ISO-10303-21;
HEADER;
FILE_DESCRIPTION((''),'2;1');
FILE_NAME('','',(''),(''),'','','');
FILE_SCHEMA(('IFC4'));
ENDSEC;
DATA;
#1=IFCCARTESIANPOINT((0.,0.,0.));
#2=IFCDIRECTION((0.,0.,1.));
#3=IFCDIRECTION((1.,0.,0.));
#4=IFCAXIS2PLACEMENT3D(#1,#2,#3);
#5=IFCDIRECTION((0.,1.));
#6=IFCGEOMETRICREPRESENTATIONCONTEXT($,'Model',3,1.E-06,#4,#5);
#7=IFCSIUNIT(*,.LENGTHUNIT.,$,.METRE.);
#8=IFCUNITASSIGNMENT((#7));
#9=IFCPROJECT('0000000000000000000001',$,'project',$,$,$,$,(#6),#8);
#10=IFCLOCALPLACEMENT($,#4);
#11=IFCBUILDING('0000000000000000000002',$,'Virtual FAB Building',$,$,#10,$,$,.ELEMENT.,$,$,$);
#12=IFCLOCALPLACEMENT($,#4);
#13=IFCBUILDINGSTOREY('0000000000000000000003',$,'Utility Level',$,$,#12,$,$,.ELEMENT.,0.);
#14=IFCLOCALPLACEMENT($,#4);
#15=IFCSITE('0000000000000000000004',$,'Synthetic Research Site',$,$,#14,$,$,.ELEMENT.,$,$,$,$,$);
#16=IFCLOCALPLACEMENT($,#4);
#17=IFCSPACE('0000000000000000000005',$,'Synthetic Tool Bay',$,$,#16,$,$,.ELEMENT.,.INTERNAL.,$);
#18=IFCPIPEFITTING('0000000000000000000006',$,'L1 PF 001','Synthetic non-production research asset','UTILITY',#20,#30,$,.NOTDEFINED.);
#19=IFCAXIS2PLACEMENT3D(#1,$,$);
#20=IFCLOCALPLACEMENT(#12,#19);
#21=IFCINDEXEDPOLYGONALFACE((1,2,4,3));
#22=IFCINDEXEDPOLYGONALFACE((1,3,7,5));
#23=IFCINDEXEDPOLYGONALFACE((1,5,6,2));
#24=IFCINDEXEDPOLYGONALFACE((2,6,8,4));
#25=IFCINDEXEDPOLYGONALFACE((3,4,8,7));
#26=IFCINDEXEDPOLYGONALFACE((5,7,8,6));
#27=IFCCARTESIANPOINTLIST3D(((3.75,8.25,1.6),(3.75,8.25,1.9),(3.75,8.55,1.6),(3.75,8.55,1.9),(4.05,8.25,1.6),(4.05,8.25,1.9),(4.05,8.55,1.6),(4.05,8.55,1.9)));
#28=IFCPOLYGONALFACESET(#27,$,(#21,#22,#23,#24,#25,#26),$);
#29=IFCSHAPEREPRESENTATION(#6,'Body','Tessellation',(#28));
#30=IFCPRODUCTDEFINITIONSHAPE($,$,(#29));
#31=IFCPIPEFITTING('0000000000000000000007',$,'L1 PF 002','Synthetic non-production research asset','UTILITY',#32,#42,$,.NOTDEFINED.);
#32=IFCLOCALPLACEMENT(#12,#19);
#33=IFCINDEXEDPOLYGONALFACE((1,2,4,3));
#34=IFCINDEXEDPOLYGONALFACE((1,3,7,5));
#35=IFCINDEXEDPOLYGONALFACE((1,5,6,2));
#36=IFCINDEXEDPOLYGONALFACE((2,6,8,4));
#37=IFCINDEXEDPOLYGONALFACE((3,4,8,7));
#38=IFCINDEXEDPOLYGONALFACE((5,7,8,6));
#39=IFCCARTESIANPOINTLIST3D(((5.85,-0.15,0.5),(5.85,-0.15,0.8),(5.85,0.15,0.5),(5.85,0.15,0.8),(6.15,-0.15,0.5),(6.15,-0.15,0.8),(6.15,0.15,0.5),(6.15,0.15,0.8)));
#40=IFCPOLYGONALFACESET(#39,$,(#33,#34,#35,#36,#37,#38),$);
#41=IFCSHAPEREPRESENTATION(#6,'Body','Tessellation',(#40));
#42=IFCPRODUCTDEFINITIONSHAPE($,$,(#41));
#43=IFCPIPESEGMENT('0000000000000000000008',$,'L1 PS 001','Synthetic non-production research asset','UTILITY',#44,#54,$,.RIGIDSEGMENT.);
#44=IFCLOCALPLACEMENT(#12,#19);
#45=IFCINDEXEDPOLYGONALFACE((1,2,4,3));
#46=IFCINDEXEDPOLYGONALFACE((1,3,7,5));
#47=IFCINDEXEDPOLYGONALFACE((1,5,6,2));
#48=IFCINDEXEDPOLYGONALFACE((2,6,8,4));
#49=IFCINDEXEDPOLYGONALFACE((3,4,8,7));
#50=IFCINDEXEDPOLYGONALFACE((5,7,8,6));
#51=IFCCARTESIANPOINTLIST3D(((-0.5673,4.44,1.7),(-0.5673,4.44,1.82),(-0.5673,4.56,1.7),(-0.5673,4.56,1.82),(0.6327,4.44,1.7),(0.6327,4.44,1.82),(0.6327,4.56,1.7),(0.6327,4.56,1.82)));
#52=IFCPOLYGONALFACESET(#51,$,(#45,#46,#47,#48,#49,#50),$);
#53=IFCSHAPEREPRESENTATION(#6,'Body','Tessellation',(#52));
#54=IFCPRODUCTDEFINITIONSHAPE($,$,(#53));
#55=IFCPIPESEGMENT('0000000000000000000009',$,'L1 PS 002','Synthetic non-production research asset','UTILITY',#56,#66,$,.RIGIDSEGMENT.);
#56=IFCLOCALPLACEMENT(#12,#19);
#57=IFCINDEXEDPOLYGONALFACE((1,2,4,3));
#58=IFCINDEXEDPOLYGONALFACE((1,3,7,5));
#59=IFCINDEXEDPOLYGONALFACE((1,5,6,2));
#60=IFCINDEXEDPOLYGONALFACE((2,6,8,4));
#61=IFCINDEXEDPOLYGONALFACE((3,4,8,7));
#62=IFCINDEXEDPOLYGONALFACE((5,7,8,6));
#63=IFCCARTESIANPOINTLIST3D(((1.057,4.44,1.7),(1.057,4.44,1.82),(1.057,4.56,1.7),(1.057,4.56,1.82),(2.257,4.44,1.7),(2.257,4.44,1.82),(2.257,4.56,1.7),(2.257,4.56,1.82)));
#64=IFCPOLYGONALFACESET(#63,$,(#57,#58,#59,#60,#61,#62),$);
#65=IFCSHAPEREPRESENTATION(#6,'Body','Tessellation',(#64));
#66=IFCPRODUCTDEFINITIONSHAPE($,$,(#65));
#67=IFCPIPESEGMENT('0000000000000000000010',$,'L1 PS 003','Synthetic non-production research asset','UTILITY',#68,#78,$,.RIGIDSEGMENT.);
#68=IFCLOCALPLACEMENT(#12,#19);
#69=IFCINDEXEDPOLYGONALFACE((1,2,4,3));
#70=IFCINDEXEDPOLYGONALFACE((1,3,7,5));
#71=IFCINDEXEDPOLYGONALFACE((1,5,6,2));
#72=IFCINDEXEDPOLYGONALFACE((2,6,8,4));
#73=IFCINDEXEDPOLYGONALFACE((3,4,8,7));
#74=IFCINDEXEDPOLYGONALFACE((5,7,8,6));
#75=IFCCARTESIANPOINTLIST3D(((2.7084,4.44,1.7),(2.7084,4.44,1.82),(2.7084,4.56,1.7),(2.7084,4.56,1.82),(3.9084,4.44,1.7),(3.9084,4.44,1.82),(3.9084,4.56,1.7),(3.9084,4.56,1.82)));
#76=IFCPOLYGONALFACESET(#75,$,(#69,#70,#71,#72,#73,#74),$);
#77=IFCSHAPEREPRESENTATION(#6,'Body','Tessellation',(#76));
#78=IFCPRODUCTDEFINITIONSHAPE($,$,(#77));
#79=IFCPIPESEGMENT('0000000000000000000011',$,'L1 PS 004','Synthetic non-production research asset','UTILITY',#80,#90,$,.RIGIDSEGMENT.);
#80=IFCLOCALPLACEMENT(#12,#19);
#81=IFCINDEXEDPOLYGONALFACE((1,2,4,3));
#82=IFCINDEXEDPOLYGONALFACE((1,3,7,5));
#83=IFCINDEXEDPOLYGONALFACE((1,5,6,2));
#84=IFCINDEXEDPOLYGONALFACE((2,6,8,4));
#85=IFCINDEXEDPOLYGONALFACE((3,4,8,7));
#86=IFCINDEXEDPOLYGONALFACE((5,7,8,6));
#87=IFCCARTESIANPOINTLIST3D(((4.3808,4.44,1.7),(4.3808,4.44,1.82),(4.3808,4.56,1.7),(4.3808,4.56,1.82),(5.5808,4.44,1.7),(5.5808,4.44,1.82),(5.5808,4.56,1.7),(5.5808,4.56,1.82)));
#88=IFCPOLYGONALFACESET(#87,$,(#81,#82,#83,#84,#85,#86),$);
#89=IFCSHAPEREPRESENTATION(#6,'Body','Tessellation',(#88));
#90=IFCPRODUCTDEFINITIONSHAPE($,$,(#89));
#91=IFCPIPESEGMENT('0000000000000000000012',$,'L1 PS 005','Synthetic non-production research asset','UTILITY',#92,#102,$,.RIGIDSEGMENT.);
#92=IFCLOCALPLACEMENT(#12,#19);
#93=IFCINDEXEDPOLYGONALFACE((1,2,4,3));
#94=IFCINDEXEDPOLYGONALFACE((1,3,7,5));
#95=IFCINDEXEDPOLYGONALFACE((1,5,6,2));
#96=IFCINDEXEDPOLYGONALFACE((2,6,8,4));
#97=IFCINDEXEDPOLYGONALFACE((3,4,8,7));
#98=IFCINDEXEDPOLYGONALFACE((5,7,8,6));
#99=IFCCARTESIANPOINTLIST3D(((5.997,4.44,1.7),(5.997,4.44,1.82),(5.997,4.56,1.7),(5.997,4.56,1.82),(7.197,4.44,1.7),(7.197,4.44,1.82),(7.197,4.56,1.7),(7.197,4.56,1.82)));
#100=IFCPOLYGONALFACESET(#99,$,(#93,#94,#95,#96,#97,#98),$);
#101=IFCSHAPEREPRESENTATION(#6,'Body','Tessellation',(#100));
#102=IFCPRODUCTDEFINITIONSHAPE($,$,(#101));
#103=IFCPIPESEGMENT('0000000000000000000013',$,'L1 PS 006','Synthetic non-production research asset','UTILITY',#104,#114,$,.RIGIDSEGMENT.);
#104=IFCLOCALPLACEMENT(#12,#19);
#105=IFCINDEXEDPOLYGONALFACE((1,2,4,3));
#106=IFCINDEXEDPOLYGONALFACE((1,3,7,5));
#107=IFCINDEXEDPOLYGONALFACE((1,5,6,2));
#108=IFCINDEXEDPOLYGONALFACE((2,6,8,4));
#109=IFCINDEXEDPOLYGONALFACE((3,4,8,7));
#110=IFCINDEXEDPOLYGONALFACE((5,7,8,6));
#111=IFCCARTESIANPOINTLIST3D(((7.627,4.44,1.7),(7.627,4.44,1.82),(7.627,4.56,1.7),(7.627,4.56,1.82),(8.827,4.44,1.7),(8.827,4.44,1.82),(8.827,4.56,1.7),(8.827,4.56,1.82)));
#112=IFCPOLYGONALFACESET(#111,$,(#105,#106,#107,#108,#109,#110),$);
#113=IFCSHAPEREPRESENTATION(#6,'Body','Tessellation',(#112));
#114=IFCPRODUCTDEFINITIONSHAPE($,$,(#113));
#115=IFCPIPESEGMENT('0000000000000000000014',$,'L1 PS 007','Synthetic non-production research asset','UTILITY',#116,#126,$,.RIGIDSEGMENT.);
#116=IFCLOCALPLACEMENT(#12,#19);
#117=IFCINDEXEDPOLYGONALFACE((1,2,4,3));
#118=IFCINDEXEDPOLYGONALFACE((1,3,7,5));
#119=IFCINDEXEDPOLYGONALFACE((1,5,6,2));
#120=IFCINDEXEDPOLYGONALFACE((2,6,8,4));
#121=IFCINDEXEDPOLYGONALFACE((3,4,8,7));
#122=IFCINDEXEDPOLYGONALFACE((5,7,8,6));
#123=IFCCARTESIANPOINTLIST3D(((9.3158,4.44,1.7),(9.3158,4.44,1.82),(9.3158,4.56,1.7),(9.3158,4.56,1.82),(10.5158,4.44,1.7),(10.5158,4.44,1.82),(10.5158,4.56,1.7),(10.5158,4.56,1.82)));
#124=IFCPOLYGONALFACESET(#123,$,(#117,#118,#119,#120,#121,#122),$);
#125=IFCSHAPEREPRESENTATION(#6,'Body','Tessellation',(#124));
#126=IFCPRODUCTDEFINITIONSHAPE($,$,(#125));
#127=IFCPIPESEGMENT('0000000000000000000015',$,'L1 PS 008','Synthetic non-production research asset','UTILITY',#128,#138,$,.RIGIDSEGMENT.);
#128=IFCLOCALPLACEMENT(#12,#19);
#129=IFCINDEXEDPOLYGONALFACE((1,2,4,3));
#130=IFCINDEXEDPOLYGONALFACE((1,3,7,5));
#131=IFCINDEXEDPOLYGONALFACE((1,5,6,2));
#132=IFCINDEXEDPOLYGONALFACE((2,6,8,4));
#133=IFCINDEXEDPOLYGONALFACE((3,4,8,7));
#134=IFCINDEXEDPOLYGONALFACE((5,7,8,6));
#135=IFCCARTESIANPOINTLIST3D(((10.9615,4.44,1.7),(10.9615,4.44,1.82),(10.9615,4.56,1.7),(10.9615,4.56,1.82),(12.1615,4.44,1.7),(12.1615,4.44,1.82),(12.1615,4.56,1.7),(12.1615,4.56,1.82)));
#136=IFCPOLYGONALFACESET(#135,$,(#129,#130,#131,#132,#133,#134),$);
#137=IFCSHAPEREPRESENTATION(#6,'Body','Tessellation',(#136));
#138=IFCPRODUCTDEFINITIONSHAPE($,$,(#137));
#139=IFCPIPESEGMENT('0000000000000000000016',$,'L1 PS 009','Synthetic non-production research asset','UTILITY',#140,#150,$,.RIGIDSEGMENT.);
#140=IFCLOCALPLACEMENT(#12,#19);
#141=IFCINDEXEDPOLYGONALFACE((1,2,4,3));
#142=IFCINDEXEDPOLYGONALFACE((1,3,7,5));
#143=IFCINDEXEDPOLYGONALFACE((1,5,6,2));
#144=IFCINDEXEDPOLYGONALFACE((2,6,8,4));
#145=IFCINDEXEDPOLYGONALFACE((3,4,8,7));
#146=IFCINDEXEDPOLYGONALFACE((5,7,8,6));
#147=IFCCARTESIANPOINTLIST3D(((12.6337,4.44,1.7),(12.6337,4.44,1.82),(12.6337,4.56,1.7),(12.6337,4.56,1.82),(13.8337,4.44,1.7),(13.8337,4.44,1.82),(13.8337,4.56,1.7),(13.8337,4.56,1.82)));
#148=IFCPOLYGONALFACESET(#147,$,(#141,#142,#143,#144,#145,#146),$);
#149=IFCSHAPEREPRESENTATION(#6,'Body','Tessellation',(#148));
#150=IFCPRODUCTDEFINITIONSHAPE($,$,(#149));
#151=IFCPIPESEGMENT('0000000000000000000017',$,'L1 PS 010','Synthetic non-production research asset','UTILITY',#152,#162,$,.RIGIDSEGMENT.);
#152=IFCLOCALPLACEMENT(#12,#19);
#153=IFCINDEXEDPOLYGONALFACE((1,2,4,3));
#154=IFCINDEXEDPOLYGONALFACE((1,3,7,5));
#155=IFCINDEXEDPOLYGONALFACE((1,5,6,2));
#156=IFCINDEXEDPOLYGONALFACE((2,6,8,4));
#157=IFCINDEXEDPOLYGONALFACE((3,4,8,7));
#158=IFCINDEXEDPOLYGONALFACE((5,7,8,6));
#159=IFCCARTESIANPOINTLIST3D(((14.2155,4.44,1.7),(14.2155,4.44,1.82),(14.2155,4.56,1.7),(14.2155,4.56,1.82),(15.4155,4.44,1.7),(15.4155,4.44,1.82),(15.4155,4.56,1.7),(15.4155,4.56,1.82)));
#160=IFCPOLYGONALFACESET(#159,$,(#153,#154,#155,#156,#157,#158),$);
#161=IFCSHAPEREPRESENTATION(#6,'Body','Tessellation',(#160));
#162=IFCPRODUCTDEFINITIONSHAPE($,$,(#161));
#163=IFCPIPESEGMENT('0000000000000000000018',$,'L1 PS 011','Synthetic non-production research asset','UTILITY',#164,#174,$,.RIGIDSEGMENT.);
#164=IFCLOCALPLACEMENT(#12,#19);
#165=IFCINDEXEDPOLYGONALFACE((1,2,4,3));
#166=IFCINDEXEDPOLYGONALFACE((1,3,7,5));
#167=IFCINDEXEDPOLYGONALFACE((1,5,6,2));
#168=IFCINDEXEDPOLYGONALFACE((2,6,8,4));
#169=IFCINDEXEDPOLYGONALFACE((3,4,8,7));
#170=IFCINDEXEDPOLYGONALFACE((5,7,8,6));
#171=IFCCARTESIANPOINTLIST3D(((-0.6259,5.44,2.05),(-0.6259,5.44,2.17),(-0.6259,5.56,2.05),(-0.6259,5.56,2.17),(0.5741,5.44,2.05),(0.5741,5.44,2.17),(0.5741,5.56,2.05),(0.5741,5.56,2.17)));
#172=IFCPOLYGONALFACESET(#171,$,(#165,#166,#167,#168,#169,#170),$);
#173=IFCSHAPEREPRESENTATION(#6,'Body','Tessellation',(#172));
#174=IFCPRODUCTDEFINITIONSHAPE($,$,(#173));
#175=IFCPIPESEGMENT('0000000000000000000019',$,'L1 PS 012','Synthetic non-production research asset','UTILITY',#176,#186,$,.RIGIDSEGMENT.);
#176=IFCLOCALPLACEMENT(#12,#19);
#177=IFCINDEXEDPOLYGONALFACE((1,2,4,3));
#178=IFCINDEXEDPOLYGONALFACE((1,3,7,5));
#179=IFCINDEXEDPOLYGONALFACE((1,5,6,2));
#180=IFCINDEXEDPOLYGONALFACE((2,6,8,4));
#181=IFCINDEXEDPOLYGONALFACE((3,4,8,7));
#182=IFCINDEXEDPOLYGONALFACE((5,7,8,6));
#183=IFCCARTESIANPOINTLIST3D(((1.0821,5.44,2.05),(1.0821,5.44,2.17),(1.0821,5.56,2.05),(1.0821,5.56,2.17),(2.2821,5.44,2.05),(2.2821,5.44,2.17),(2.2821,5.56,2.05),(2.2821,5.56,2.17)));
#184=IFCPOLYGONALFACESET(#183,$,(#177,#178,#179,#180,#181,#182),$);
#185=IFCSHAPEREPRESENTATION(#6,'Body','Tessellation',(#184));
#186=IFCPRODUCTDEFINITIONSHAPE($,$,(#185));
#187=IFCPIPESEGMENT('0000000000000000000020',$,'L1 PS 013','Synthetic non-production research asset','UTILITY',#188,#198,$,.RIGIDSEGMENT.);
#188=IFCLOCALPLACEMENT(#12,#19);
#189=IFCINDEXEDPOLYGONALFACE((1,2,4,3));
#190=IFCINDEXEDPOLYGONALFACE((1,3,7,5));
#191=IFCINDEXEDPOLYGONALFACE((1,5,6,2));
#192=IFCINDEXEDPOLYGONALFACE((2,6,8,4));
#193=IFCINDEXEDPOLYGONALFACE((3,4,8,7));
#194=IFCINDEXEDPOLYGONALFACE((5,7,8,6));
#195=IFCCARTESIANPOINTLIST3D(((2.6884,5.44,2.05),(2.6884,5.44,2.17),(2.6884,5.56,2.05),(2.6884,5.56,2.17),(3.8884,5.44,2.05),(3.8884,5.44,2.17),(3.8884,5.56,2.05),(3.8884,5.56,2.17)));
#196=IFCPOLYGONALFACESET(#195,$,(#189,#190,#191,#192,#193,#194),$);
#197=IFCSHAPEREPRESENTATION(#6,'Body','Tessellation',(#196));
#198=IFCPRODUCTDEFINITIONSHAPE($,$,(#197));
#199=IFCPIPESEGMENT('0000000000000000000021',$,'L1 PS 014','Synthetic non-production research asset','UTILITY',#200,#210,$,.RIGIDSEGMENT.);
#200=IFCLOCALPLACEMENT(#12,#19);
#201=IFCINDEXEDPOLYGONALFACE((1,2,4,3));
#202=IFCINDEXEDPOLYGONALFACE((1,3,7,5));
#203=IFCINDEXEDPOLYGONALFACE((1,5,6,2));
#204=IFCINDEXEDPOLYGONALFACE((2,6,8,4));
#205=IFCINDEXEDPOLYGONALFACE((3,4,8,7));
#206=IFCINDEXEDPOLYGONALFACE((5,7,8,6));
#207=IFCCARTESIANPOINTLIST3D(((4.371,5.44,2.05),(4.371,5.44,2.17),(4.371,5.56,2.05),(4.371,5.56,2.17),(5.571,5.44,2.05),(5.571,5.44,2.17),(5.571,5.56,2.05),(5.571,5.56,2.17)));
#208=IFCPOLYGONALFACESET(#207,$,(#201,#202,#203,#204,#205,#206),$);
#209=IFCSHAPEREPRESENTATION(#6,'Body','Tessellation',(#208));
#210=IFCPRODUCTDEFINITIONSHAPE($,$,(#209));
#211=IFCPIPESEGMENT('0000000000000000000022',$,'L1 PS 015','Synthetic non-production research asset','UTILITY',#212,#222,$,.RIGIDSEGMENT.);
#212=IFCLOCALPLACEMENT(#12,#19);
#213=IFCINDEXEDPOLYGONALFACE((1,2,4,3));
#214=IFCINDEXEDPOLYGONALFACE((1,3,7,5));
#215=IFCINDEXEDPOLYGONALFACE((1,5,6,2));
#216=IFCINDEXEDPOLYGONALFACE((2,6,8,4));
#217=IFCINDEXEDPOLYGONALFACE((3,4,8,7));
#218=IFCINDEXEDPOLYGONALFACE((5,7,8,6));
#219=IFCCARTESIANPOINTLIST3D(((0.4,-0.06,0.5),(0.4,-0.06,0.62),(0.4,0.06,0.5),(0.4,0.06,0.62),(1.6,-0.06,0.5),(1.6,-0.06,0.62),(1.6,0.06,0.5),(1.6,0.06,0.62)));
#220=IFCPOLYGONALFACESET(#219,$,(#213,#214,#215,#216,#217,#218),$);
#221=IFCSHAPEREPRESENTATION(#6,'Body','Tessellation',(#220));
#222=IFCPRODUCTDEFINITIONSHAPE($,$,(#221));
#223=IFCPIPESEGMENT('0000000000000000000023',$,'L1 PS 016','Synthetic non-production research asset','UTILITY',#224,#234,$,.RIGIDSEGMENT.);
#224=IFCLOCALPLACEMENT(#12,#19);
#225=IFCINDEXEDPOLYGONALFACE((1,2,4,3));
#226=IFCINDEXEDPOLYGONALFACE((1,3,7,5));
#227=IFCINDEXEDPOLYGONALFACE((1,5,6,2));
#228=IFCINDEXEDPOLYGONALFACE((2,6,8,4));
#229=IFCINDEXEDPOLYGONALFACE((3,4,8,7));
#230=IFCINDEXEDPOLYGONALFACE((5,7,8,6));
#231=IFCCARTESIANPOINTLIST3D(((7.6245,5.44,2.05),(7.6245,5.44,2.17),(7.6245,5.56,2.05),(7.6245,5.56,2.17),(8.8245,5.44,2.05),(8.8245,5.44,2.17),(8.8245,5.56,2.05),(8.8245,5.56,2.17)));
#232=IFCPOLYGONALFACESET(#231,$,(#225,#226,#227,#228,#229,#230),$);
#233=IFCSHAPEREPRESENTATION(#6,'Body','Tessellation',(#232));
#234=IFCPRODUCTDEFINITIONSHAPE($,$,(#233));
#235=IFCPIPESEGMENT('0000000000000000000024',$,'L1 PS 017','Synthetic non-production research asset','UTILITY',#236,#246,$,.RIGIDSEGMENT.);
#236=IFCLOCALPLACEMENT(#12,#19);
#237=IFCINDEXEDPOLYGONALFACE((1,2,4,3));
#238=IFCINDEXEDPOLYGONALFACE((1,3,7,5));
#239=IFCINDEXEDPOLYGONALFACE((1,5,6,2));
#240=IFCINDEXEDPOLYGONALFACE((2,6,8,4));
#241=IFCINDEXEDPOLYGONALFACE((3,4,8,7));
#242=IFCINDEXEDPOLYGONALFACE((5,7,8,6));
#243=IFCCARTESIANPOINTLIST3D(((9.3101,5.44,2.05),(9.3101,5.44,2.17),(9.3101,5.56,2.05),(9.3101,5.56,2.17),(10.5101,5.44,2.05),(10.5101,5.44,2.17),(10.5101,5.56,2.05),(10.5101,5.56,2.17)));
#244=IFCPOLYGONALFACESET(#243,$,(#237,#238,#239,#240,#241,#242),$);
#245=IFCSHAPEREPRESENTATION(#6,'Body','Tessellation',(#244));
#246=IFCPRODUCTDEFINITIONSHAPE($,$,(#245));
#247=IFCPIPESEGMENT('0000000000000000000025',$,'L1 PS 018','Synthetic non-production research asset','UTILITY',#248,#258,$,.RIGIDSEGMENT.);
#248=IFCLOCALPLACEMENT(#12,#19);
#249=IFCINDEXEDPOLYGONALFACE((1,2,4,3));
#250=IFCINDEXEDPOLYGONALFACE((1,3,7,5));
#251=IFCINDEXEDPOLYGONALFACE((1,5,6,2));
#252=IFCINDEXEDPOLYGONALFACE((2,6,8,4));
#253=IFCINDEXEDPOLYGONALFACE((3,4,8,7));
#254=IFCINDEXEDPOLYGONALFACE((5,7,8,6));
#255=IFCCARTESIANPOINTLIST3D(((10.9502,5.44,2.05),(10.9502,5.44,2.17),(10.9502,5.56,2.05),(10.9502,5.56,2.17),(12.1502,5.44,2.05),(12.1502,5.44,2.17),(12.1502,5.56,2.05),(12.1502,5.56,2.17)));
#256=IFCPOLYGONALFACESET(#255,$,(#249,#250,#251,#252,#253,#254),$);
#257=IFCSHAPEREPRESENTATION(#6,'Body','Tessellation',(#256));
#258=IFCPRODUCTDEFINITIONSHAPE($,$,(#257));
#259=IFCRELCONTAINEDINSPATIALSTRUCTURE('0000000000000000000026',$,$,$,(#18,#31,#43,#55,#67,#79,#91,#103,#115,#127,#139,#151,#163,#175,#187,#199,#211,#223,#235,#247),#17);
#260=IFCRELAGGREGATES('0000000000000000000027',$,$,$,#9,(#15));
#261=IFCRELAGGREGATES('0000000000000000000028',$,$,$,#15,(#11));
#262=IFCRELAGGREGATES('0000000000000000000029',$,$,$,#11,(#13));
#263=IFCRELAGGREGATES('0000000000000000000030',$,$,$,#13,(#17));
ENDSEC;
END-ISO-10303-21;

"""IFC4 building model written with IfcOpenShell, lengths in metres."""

from ifc_helpers import new_model, si_unit, direction, frame, origin_with_axes, origin_2d_with_axis, place, context, project, spatial, rectangle, extrude, element, save


model = new_model("IFC4")

# Units and contexts
model_context = context("Model", 3, precision=1e-06, world=origin_with_axes(), true_north=direction((0.0, 1.0)))
ifc_project = project(units=[si_unit("LENGTHUNIT", "METRE")], contexts=[model_context])

# Site, building, storey, space
site_placement = place(None, origin_with_axes())
site = spatial("IfcSite", under=ifc_project, at=site_placement, Name="Synthetic Research Site", CompositionType="ELEMENT")
building_placement = place(None, origin_with_axes())
building = spatial("IfcBuilding", under=site, at=building_placement, Name="Virtual FAB Building", CompositionType="ELEMENT")
storey_placement = place(None, origin_with_axes())
storey = spatial("IfcBuildingStorey", under=building, at=storey_placement, Name="Utility Level", CompositionType="ELEMENT", Elevation=0.0)
space_placement = place(None, origin_with_axes())
space = spatial("IfcSpace", under=storey, at=space_placement, Name="Synthetic Tool Bay", CompositionType="ELEMENT", PredefinedType="INTERNAL")

# Pipe fittings
for number, where, z_axis, x_axis, name in (
    (1, (3.9, 8.4, 1.6), (0.0, 0.0, 1.0), (1.0, 0.0, 0.0), "L1 PF 001"),
    (2, (6.0, 0.0, 0.5), (0.0, 0.0, 1.0), (1.0, 0.0, 0.0), "L1 PF 002"),
):
    element("IfcPipeFitting", number, at=place(None, frame(where, z_axis=z_axis, x_axis=x_axis)), inside=space, Name=name, Description="Synthetic non-production research asset", ObjectType="UTILITY", PredefinedType="NOTDEFINED", context=model_context, shape_type="SweptSolid", body=[
        extrude(rectangle(XDim=0.3, YDim=0.3, at=origin_2d_with_axis()), origin_with_axes(), (0.0, 0.0, 1.0), 0.3),
    ])

# Pipe segments
for number, where, z_axis, x_axis, name in (
    (3, (0.0327, 4.5, 1.7), (0.0, 0.0, 1.0), (1.0, 0.0, 0.0), "L1 PS 001"),
    (4, (1.657, 4.5, 1.7), (0.0, 0.0, 1.0), (1.0, 0.0, 0.0), "L1 PS 002"),
    (5, (3.3084, 4.5, 1.7), (0.0, 0.0, 1.0), (1.0, 0.0, 0.0), "L1 PS 003"),
    (6, (4.9808, 4.5, 1.7), (0.0, 0.0, 1.0), (1.0, 0.0, 0.0), "L1 PS 004"),
    (7, (6.597, 4.5, 1.7), (0.0, 0.0, 1.0), (1.0, 0.0, 0.0), "L1 PS 005"),
    (8, (8.227, 4.5, 1.7), (0.0, 0.0, 1.0), (1.0, 0.0, 0.0), "L1 PS 006"),
    (9, (9.9158, 4.5, 1.7), (0.0, 0.0, 1.0), (1.0, 0.0, 0.0), "L1 PS 007"),
    (10, (11.5615, 4.5, 1.7), (0.0, 0.0, 1.0), (1.0, 0.0, 0.0), "L1 PS 008"),
    (11, (13.2337, 4.5, 1.7), (0.0, 0.0, 1.0), (1.0, 0.0, 0.0), "L1 PS 009"),
    (12, (14.8155, 4.5, 1.7), (0.0, 0.0, 1.0), (1.0, 0.0, 0.0), "L1 PS 010"),
    (13, (-0.0259, 5.5, 2.05), (0.0, 0.0, 1.0), (1.0, 0.0, 0.0), "L1 PS 011"),
    (14, (1.6821, 5.5, 2.05), (0.0, 0.0, 1.0), (1.0, 0.0, 0.0), "L1 PS 012"),
    (15, (3.2884, 5.5, 2.05), (0.0, 0.0, 1.0), (1.0, 0.0, 0.0), "L1 PS 013"),
    (16, (4.971, 5.5, 2.05), (0.0, 0.0, 1.0), (1.0, 0.0, 0.0), "L1 PS 014"),
    (17, (1.0, 0.0, 0.5), (0.0, 0.0, 1.0), (1.0, 0.0, 0.0), "L1 PS 015"),
    (18, (8.2245, 5.5, 2.05), (0.0, 0.0, 1.0), (1.0, 0.0, 0.0), "L1 PS 016"),
    (19, (9.9101, 5.5, 2.05), (0.0, 0.0, 1.0), (1.0, 0.0, 0.0), "L1 PS 017"),
    (20, (11.5502, 5.5, 2.05), (0.0, 0.0, 1.0), (1.0, 0.0, 0.0), "L1 PS 018"),
):
    element("IfcPipeSegment", number, at=place(None, frame(where, z_axis=z_axis, x_axis=x_axis)), inside=space, Name=name, Description="Synthetic non-production research asset", ObjectType="UTILITY", PredefinedType="RIGIDSEGMENT", context=model_context, shape_type="SweptSolid", body=[
        extrude(rectangle(XDim=1.2, YDim=0.12, at=origin_2d_with_axis()), origin_with_axes(), (0.0, 0.0, 1.0), 0.12),
    ])

save(model, "model.ifc")
